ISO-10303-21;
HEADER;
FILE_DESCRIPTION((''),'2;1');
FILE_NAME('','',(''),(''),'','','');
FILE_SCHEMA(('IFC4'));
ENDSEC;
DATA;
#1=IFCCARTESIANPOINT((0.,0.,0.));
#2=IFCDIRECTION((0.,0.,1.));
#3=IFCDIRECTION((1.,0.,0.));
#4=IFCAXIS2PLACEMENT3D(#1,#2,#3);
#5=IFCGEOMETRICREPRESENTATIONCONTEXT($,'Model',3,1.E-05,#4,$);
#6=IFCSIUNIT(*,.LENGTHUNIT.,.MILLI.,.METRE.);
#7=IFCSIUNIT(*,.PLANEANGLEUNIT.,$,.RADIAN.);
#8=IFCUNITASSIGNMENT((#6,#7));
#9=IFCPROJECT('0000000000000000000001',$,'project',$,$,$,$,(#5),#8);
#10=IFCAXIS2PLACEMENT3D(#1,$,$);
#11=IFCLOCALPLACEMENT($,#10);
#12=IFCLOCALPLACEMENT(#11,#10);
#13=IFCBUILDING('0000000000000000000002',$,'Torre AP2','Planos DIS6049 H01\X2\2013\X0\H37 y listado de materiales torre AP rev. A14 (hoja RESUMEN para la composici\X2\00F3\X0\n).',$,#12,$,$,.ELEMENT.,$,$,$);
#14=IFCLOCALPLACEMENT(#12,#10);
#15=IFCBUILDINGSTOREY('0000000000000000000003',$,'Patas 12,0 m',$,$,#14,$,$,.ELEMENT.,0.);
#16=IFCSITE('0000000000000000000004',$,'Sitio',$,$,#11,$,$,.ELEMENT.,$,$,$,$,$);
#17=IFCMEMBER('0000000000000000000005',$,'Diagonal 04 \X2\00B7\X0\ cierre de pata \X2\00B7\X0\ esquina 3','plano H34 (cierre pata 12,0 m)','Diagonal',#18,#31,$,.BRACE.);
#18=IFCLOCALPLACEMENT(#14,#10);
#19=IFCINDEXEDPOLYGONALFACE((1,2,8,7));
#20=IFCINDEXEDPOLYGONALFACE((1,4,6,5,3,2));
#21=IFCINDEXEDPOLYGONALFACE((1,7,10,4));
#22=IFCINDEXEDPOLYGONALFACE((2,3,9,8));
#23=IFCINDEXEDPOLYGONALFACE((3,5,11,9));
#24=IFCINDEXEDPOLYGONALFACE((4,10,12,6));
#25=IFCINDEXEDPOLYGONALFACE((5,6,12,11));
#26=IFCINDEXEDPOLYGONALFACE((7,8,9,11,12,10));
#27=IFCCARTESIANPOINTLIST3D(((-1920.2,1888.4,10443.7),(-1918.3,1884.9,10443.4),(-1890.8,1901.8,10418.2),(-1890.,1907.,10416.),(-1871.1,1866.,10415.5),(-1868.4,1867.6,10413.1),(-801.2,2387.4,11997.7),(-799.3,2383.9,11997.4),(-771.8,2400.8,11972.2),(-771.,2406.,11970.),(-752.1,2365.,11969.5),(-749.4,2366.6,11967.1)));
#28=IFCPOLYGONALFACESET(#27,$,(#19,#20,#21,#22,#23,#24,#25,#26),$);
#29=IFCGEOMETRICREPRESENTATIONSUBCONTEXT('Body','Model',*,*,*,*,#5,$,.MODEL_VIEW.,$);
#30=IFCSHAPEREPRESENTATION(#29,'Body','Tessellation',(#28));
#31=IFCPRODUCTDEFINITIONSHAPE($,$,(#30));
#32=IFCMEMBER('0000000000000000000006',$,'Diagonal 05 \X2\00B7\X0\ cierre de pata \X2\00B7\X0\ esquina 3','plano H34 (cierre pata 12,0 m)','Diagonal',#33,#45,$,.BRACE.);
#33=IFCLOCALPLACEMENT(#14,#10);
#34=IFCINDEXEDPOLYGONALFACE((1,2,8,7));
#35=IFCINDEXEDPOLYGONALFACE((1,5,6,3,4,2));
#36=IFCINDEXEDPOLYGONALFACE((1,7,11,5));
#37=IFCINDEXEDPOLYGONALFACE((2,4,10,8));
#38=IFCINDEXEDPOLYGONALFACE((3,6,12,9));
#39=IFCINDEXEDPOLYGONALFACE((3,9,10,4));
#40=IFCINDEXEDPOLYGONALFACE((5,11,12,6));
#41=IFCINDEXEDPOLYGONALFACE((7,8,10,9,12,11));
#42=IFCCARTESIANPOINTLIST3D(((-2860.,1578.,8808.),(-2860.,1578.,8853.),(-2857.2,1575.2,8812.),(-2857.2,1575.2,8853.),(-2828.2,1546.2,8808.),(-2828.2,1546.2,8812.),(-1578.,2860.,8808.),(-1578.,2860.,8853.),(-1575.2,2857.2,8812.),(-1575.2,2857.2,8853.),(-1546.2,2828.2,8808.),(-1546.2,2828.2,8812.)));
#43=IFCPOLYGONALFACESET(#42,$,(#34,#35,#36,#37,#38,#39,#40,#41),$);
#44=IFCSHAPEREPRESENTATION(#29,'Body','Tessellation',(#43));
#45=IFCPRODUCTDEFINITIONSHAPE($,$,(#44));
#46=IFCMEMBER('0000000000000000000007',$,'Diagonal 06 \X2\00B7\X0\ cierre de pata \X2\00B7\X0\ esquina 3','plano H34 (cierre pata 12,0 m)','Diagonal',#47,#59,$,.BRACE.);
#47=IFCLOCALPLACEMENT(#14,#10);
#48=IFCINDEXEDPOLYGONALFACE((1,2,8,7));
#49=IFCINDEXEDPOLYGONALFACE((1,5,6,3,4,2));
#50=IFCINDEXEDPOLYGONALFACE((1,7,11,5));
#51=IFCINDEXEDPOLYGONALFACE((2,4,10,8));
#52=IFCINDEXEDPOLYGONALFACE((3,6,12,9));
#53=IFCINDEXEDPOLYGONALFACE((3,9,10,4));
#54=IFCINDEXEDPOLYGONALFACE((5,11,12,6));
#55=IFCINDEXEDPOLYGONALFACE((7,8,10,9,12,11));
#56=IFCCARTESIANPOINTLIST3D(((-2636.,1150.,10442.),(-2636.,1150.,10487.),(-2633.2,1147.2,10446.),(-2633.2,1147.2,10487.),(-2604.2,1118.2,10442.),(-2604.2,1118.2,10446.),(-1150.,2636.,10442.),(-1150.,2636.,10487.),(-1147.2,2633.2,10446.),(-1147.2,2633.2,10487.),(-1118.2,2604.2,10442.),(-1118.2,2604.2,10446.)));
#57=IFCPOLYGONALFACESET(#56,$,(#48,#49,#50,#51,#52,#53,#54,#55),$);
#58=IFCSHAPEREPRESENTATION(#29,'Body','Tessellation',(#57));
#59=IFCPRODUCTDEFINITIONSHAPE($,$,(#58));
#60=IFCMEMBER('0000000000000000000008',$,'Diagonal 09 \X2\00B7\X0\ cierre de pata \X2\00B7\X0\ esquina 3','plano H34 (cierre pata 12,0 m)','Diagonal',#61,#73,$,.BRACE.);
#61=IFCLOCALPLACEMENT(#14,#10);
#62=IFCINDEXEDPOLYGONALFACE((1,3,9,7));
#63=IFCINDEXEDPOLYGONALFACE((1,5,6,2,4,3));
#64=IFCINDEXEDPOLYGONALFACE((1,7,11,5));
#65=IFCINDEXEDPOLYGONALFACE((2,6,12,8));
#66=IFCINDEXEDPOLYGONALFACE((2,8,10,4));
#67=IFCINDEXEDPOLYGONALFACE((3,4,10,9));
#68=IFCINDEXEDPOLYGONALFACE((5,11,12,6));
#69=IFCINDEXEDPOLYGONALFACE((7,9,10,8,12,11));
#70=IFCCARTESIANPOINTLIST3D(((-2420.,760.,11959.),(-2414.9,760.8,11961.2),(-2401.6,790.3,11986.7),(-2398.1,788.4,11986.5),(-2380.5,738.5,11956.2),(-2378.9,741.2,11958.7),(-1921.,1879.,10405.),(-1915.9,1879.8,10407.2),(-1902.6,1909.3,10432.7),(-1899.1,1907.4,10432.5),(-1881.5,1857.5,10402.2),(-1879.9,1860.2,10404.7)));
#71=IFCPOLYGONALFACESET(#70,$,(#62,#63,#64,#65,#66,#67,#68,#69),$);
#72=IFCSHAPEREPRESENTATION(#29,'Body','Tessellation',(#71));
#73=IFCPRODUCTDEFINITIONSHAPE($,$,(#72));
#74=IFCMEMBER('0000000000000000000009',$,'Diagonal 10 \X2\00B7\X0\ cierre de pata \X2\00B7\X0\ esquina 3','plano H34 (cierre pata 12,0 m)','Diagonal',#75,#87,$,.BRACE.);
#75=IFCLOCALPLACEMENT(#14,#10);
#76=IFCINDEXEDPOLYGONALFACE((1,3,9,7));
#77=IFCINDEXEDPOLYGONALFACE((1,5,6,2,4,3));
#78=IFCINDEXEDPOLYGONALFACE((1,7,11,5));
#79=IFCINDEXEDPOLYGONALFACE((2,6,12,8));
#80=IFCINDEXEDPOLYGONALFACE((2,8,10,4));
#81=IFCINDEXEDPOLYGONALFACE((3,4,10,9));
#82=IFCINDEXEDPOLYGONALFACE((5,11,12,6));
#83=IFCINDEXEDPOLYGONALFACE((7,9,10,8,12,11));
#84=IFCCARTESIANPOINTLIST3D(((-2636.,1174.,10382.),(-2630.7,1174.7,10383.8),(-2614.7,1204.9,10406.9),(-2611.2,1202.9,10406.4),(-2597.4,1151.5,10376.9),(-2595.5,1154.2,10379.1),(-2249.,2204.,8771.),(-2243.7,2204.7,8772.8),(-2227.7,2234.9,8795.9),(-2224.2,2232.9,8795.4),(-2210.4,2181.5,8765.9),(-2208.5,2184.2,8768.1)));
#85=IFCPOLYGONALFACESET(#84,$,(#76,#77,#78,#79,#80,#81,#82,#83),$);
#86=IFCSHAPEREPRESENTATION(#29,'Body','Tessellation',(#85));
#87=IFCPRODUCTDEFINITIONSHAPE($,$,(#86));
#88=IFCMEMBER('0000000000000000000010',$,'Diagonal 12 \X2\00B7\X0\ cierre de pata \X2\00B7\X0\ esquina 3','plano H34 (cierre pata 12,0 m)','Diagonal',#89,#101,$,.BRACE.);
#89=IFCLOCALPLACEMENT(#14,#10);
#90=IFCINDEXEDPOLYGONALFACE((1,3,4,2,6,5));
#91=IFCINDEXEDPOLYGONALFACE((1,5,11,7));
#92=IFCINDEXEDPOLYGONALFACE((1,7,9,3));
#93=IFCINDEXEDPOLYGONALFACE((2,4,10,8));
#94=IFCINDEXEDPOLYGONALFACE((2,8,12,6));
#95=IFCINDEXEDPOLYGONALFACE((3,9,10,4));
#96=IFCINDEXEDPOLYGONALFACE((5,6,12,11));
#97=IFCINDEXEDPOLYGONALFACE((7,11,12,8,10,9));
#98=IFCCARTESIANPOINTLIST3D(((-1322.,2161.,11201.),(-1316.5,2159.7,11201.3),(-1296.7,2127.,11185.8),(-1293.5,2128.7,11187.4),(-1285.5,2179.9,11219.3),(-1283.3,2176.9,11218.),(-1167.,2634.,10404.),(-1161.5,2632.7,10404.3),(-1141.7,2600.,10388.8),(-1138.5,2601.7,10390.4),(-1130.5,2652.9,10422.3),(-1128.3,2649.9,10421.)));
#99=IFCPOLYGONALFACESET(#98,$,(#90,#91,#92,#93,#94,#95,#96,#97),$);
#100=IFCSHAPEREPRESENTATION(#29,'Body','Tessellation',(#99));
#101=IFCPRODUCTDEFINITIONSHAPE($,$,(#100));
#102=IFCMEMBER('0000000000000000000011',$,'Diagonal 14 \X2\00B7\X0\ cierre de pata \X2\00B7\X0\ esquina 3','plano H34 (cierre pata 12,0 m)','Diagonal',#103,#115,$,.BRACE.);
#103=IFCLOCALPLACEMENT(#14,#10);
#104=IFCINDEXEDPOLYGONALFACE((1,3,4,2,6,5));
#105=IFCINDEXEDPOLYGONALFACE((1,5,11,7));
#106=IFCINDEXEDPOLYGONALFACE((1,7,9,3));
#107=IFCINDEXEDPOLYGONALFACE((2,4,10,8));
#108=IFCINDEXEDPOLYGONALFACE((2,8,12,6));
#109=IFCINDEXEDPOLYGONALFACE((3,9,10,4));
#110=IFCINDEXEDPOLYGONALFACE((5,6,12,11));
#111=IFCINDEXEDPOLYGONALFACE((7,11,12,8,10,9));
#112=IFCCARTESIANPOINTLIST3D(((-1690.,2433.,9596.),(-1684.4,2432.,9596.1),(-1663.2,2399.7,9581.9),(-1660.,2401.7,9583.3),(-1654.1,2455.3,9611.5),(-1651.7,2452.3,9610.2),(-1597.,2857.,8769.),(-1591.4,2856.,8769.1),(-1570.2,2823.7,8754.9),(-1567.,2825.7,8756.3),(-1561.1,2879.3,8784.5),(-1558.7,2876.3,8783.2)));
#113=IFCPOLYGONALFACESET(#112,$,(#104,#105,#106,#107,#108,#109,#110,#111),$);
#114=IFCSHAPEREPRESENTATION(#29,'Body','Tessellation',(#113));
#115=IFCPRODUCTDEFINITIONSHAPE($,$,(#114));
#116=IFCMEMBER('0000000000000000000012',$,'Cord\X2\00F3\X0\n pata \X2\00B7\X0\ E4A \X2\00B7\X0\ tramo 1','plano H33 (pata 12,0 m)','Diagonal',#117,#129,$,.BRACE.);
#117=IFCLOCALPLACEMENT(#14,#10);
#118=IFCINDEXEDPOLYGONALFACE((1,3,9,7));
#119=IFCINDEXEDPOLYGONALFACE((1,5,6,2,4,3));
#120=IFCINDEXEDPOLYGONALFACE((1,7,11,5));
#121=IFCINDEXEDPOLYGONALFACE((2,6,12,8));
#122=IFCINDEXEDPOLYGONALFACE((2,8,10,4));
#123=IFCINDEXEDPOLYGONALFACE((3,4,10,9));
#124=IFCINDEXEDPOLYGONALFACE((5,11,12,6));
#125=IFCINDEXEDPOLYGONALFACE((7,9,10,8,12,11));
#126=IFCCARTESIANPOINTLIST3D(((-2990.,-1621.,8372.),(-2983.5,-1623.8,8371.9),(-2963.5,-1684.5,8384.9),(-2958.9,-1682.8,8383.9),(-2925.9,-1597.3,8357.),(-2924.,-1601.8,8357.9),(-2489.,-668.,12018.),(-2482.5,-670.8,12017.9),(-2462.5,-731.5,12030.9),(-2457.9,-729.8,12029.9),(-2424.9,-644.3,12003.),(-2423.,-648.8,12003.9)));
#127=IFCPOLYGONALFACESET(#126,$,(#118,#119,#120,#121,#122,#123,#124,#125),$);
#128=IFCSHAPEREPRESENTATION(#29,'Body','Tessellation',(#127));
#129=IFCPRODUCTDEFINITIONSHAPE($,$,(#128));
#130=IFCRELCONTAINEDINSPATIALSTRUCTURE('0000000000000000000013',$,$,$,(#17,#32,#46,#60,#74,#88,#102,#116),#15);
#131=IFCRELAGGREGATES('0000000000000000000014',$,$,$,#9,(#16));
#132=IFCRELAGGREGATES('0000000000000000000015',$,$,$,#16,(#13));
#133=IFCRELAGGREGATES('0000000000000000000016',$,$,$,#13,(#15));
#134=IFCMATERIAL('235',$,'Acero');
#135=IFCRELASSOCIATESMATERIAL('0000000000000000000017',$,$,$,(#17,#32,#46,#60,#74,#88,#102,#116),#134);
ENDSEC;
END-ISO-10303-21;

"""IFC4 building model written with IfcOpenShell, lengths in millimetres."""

from ifc_helpers import new_model, si_unit, frame, frame_2d, origin, origin_with_axes, place, context, subcontext, project, spatial, l_section, extrude, material, element, save


model = new_model("IFC4")

# Units and contexts
model_context = context("Model", 3, precision=1e-05, world=origin_with_axes())
body_context = subcontext(model_context, "Body", "Model", "MODEL_VIEW")
ifc_project = project(units=[si_unit("LENGTHUNIT", "METRE", prefix="MILLI"), si_unit("PLANEANGLEUNIT", "RADIAN")], contexts=[model_context])

# Site, building, storey
site_placement = place(None, origin())
site = spatial("IfcSite", under=ifc_project, at=site_placement, Name="Sitio", CompositionType="ELEMENT")
building_placement = place(site_placement, origin())
building = spatial("IfcBuilding", under=site, at=building_placement, Name="Torre AP2", Description="Planos DIS6049 H01–H37 y listado de materiales torre AP rev. A14 (hoja RESUMEN para la composición).", CompositionType="ELEMENT")
storey_placement = place(building_placement, origin())
storey = spatial("IfcBuildingStorey", under=building, at=storey_placement, Name="Patas 12,0 m", CompositionType="ELEMENT", Elevation=0.0)

# Members
ifc_material_1 = material(Name="235", Category="Acero")
member_1_placement = place(storey_placement, frame((-771.0, 2406.0, 11970.0), z_axis=(-0.565463, -0.252159, -0.785281), x_axis=(0.480163, -0.874778, -0.064857)))
element("IfcMember", 1, at=member_1_placement, inside=storey, material=ifc_material_1, Name="Diagonal 04 · cierre de pata · esquina 3", Description="plano H34 (cierre pata 12,0 m)", ObjectType="Diagonal", PredefinedType="BRACE", context=body_context, shape_type="SweptSolid", body=[
    extrude(l_section(Depth=45.0, Width=45.0, Thickness=4.0, at=frame_2d((22.5, 22.5))), None, (0.0, 0.0, 1.0), 1978.9),
])
member_2_placement = place(storey_placement, frame((-1578.0, 2860.0, 8808.0), z_axis=(-0.707107, -0.707107, 0.0), x_axis=(0.707107, -0.707107, 0.0)))
element("IfcMember", 2, at=member_2_placement, inside=storey, material=ifc_material_1, Name="Diagonal 05 · cierre de pata · esquina 3", Description="plano H34 (cierre pata 12,0 m)", ObjectType="Diagonal", PredefinedType="BRACE", context=body_context, shape_type="SweptSolid", body=[
    extrude(l_section(Depth=45.0, Width=45.0, Thickness=4.0, at=frame_2d((22.5, 22.5))), None, (0.0, 0.0, 1.0), 1813.0),
])
member_3_placement = place(storey_placement, frame((-1150.0, 2636.0, 10442.0), z_axis=(-0.707107, -0.707107, 0.0), x_axis=(0.707107, -0.707107, 0.0)))
element("IfcMember", 3, at=member_3_placement, inside=storey, material=ifc_material_1, Name="Diagonal 06 · cierre de pata · esquina 3", Description="plano H34 (cierre pata 12,0 m)", ObjectType="Diagonal", PredefinedType="BRACE", context=body_context, shape_type="SweptSolid", body=[
    extrude(l_section(Depth=45.0, Width=45.0, Thickness=4.0, at=frame_2d((22.5, 22.5))), None, (0.0, 0.0, 1.0), 2101.5),
])
member_4_placement = place(storey_placement, frame((-1921.0, 1879.0, 10405.0), z_axis=(-0.252159, -0.565463, 0.785281), x_axis=(0.876918, -0.476669, -0.061654)))
element("IfcMember", 4, at=member_4_placement, inside=storey, material=ifc_material_1, Name="Diagonal 09 · cierre de pata · esquina 3", Description="plano H34 (cierre pata 12,0 m)", ObjectType="Diagonal", PredefinedType="BRACE", context=body_context, shape_type="SweptSolid", body=[
    extrude(l_section(Depth=45.0, Width=45.0, Thickness=4.0, at=frame_2d((22.5, 22.5))), None, (0.0, 0.0, 1.0), 1978.9),
])
member_5_placement = place(storey_placement, frame((-2249.0, 2204.0, 8771.0), z_axis=(-0.198371, -0.527963, 0.825775), x_axis=(0.857806, -0.5011, -0.114315)))
element("IfcMember", 5, at=member_5_placement, inside=storey, material=ifc_material_1, Name="Diagonal 10 · cierre de pata · esquina 3", Description="plano H34 (cierre pata 12,0 m)", ObjectType="Diagonal", PredefinedType="BRACE", context=body_context, shape_type="SweptSolid", body=[
    extrude(l_section(Depth=45.0, Width=45.0, Thickness=4.0, at=frame_2d((22.5, 22.5))), None, (0.0, 0.0, 1.0), 1950.9),
])
member_6_placement = place(storey_placement, frame((-1167.0, 2634.0, 10404.0), z_axis=(-0.164953, -0.503373, 0.848178), x_axis=(0.561924, -0.754706, -0.338617)))
element("IfcMember", 6, at=member_6_placement, inside=storey, material=ifc_material_1, Name="Diagonal 12 · cierre de pata · esquina 3", Description="plano H34 (cierre pata 12,0 m)", ObjectType="Diagonal", PredefinedType="BRACE", context=body_context, shape_type="SweptSolid", body=[
    extrude(l_section(Depth=45.0, Width=45.0, Thickness=4.0, at=frame_2d((22.5, 22.5))), None, (0.0, 0.0, 1.0), 939.7),
])
member_7_placement = place(storey_placement, frame((-1597.0, 2857.0, 8769.0), z_axis=(-0.099572, -0.453962, 0.88544), x_axis=(0.594896, -0.740469, -0.312737)))
element("IfcMember", 7, at=member_7_placement, inside=storey, material=ifc_material_1, Name="Diagonal 14 · cierre de pata · esquina 3", Description="plano H34 (cierre pata 12,0 m)", ObjectType="Diagonal", PredefinedType="BRACE", context=body_context, shape_type="SweptSolid", body=[
    extrude(l_section(Depth=45.0, Width=45.0, Thickness=4.0, at=frame_2d((22.5, 22.5))), None, (0.0, 0.0, 1.0), 934.0),
])
member_8_placement = place(storey_placement, frame((-2489.0, -668.0, 12018.0), z_axis=(-0.131785, -0.250681, -0.959058), x_axis=(0.916032, 0.338951, -0.214469)))
element("IfcMember", 8, at=member_8_placement, inside=storey, material=ifc_material_1, Name="Cordón pata · E4A · tramo 1", Description="plano H33 (pata 12,0 m)", ObjectType="Diagonal", PredefinedType="BRACE", context=body_context, shape_type="SweptSolid", body=[
    extrude(l_section(Depth=70.0, Width=70.0, Thickness=5.0, at=frame_2d((35.0, 35.0))), None, (0.0, 0.0, 1.0), 3801.6),
])

save(model, "model.ifc")
